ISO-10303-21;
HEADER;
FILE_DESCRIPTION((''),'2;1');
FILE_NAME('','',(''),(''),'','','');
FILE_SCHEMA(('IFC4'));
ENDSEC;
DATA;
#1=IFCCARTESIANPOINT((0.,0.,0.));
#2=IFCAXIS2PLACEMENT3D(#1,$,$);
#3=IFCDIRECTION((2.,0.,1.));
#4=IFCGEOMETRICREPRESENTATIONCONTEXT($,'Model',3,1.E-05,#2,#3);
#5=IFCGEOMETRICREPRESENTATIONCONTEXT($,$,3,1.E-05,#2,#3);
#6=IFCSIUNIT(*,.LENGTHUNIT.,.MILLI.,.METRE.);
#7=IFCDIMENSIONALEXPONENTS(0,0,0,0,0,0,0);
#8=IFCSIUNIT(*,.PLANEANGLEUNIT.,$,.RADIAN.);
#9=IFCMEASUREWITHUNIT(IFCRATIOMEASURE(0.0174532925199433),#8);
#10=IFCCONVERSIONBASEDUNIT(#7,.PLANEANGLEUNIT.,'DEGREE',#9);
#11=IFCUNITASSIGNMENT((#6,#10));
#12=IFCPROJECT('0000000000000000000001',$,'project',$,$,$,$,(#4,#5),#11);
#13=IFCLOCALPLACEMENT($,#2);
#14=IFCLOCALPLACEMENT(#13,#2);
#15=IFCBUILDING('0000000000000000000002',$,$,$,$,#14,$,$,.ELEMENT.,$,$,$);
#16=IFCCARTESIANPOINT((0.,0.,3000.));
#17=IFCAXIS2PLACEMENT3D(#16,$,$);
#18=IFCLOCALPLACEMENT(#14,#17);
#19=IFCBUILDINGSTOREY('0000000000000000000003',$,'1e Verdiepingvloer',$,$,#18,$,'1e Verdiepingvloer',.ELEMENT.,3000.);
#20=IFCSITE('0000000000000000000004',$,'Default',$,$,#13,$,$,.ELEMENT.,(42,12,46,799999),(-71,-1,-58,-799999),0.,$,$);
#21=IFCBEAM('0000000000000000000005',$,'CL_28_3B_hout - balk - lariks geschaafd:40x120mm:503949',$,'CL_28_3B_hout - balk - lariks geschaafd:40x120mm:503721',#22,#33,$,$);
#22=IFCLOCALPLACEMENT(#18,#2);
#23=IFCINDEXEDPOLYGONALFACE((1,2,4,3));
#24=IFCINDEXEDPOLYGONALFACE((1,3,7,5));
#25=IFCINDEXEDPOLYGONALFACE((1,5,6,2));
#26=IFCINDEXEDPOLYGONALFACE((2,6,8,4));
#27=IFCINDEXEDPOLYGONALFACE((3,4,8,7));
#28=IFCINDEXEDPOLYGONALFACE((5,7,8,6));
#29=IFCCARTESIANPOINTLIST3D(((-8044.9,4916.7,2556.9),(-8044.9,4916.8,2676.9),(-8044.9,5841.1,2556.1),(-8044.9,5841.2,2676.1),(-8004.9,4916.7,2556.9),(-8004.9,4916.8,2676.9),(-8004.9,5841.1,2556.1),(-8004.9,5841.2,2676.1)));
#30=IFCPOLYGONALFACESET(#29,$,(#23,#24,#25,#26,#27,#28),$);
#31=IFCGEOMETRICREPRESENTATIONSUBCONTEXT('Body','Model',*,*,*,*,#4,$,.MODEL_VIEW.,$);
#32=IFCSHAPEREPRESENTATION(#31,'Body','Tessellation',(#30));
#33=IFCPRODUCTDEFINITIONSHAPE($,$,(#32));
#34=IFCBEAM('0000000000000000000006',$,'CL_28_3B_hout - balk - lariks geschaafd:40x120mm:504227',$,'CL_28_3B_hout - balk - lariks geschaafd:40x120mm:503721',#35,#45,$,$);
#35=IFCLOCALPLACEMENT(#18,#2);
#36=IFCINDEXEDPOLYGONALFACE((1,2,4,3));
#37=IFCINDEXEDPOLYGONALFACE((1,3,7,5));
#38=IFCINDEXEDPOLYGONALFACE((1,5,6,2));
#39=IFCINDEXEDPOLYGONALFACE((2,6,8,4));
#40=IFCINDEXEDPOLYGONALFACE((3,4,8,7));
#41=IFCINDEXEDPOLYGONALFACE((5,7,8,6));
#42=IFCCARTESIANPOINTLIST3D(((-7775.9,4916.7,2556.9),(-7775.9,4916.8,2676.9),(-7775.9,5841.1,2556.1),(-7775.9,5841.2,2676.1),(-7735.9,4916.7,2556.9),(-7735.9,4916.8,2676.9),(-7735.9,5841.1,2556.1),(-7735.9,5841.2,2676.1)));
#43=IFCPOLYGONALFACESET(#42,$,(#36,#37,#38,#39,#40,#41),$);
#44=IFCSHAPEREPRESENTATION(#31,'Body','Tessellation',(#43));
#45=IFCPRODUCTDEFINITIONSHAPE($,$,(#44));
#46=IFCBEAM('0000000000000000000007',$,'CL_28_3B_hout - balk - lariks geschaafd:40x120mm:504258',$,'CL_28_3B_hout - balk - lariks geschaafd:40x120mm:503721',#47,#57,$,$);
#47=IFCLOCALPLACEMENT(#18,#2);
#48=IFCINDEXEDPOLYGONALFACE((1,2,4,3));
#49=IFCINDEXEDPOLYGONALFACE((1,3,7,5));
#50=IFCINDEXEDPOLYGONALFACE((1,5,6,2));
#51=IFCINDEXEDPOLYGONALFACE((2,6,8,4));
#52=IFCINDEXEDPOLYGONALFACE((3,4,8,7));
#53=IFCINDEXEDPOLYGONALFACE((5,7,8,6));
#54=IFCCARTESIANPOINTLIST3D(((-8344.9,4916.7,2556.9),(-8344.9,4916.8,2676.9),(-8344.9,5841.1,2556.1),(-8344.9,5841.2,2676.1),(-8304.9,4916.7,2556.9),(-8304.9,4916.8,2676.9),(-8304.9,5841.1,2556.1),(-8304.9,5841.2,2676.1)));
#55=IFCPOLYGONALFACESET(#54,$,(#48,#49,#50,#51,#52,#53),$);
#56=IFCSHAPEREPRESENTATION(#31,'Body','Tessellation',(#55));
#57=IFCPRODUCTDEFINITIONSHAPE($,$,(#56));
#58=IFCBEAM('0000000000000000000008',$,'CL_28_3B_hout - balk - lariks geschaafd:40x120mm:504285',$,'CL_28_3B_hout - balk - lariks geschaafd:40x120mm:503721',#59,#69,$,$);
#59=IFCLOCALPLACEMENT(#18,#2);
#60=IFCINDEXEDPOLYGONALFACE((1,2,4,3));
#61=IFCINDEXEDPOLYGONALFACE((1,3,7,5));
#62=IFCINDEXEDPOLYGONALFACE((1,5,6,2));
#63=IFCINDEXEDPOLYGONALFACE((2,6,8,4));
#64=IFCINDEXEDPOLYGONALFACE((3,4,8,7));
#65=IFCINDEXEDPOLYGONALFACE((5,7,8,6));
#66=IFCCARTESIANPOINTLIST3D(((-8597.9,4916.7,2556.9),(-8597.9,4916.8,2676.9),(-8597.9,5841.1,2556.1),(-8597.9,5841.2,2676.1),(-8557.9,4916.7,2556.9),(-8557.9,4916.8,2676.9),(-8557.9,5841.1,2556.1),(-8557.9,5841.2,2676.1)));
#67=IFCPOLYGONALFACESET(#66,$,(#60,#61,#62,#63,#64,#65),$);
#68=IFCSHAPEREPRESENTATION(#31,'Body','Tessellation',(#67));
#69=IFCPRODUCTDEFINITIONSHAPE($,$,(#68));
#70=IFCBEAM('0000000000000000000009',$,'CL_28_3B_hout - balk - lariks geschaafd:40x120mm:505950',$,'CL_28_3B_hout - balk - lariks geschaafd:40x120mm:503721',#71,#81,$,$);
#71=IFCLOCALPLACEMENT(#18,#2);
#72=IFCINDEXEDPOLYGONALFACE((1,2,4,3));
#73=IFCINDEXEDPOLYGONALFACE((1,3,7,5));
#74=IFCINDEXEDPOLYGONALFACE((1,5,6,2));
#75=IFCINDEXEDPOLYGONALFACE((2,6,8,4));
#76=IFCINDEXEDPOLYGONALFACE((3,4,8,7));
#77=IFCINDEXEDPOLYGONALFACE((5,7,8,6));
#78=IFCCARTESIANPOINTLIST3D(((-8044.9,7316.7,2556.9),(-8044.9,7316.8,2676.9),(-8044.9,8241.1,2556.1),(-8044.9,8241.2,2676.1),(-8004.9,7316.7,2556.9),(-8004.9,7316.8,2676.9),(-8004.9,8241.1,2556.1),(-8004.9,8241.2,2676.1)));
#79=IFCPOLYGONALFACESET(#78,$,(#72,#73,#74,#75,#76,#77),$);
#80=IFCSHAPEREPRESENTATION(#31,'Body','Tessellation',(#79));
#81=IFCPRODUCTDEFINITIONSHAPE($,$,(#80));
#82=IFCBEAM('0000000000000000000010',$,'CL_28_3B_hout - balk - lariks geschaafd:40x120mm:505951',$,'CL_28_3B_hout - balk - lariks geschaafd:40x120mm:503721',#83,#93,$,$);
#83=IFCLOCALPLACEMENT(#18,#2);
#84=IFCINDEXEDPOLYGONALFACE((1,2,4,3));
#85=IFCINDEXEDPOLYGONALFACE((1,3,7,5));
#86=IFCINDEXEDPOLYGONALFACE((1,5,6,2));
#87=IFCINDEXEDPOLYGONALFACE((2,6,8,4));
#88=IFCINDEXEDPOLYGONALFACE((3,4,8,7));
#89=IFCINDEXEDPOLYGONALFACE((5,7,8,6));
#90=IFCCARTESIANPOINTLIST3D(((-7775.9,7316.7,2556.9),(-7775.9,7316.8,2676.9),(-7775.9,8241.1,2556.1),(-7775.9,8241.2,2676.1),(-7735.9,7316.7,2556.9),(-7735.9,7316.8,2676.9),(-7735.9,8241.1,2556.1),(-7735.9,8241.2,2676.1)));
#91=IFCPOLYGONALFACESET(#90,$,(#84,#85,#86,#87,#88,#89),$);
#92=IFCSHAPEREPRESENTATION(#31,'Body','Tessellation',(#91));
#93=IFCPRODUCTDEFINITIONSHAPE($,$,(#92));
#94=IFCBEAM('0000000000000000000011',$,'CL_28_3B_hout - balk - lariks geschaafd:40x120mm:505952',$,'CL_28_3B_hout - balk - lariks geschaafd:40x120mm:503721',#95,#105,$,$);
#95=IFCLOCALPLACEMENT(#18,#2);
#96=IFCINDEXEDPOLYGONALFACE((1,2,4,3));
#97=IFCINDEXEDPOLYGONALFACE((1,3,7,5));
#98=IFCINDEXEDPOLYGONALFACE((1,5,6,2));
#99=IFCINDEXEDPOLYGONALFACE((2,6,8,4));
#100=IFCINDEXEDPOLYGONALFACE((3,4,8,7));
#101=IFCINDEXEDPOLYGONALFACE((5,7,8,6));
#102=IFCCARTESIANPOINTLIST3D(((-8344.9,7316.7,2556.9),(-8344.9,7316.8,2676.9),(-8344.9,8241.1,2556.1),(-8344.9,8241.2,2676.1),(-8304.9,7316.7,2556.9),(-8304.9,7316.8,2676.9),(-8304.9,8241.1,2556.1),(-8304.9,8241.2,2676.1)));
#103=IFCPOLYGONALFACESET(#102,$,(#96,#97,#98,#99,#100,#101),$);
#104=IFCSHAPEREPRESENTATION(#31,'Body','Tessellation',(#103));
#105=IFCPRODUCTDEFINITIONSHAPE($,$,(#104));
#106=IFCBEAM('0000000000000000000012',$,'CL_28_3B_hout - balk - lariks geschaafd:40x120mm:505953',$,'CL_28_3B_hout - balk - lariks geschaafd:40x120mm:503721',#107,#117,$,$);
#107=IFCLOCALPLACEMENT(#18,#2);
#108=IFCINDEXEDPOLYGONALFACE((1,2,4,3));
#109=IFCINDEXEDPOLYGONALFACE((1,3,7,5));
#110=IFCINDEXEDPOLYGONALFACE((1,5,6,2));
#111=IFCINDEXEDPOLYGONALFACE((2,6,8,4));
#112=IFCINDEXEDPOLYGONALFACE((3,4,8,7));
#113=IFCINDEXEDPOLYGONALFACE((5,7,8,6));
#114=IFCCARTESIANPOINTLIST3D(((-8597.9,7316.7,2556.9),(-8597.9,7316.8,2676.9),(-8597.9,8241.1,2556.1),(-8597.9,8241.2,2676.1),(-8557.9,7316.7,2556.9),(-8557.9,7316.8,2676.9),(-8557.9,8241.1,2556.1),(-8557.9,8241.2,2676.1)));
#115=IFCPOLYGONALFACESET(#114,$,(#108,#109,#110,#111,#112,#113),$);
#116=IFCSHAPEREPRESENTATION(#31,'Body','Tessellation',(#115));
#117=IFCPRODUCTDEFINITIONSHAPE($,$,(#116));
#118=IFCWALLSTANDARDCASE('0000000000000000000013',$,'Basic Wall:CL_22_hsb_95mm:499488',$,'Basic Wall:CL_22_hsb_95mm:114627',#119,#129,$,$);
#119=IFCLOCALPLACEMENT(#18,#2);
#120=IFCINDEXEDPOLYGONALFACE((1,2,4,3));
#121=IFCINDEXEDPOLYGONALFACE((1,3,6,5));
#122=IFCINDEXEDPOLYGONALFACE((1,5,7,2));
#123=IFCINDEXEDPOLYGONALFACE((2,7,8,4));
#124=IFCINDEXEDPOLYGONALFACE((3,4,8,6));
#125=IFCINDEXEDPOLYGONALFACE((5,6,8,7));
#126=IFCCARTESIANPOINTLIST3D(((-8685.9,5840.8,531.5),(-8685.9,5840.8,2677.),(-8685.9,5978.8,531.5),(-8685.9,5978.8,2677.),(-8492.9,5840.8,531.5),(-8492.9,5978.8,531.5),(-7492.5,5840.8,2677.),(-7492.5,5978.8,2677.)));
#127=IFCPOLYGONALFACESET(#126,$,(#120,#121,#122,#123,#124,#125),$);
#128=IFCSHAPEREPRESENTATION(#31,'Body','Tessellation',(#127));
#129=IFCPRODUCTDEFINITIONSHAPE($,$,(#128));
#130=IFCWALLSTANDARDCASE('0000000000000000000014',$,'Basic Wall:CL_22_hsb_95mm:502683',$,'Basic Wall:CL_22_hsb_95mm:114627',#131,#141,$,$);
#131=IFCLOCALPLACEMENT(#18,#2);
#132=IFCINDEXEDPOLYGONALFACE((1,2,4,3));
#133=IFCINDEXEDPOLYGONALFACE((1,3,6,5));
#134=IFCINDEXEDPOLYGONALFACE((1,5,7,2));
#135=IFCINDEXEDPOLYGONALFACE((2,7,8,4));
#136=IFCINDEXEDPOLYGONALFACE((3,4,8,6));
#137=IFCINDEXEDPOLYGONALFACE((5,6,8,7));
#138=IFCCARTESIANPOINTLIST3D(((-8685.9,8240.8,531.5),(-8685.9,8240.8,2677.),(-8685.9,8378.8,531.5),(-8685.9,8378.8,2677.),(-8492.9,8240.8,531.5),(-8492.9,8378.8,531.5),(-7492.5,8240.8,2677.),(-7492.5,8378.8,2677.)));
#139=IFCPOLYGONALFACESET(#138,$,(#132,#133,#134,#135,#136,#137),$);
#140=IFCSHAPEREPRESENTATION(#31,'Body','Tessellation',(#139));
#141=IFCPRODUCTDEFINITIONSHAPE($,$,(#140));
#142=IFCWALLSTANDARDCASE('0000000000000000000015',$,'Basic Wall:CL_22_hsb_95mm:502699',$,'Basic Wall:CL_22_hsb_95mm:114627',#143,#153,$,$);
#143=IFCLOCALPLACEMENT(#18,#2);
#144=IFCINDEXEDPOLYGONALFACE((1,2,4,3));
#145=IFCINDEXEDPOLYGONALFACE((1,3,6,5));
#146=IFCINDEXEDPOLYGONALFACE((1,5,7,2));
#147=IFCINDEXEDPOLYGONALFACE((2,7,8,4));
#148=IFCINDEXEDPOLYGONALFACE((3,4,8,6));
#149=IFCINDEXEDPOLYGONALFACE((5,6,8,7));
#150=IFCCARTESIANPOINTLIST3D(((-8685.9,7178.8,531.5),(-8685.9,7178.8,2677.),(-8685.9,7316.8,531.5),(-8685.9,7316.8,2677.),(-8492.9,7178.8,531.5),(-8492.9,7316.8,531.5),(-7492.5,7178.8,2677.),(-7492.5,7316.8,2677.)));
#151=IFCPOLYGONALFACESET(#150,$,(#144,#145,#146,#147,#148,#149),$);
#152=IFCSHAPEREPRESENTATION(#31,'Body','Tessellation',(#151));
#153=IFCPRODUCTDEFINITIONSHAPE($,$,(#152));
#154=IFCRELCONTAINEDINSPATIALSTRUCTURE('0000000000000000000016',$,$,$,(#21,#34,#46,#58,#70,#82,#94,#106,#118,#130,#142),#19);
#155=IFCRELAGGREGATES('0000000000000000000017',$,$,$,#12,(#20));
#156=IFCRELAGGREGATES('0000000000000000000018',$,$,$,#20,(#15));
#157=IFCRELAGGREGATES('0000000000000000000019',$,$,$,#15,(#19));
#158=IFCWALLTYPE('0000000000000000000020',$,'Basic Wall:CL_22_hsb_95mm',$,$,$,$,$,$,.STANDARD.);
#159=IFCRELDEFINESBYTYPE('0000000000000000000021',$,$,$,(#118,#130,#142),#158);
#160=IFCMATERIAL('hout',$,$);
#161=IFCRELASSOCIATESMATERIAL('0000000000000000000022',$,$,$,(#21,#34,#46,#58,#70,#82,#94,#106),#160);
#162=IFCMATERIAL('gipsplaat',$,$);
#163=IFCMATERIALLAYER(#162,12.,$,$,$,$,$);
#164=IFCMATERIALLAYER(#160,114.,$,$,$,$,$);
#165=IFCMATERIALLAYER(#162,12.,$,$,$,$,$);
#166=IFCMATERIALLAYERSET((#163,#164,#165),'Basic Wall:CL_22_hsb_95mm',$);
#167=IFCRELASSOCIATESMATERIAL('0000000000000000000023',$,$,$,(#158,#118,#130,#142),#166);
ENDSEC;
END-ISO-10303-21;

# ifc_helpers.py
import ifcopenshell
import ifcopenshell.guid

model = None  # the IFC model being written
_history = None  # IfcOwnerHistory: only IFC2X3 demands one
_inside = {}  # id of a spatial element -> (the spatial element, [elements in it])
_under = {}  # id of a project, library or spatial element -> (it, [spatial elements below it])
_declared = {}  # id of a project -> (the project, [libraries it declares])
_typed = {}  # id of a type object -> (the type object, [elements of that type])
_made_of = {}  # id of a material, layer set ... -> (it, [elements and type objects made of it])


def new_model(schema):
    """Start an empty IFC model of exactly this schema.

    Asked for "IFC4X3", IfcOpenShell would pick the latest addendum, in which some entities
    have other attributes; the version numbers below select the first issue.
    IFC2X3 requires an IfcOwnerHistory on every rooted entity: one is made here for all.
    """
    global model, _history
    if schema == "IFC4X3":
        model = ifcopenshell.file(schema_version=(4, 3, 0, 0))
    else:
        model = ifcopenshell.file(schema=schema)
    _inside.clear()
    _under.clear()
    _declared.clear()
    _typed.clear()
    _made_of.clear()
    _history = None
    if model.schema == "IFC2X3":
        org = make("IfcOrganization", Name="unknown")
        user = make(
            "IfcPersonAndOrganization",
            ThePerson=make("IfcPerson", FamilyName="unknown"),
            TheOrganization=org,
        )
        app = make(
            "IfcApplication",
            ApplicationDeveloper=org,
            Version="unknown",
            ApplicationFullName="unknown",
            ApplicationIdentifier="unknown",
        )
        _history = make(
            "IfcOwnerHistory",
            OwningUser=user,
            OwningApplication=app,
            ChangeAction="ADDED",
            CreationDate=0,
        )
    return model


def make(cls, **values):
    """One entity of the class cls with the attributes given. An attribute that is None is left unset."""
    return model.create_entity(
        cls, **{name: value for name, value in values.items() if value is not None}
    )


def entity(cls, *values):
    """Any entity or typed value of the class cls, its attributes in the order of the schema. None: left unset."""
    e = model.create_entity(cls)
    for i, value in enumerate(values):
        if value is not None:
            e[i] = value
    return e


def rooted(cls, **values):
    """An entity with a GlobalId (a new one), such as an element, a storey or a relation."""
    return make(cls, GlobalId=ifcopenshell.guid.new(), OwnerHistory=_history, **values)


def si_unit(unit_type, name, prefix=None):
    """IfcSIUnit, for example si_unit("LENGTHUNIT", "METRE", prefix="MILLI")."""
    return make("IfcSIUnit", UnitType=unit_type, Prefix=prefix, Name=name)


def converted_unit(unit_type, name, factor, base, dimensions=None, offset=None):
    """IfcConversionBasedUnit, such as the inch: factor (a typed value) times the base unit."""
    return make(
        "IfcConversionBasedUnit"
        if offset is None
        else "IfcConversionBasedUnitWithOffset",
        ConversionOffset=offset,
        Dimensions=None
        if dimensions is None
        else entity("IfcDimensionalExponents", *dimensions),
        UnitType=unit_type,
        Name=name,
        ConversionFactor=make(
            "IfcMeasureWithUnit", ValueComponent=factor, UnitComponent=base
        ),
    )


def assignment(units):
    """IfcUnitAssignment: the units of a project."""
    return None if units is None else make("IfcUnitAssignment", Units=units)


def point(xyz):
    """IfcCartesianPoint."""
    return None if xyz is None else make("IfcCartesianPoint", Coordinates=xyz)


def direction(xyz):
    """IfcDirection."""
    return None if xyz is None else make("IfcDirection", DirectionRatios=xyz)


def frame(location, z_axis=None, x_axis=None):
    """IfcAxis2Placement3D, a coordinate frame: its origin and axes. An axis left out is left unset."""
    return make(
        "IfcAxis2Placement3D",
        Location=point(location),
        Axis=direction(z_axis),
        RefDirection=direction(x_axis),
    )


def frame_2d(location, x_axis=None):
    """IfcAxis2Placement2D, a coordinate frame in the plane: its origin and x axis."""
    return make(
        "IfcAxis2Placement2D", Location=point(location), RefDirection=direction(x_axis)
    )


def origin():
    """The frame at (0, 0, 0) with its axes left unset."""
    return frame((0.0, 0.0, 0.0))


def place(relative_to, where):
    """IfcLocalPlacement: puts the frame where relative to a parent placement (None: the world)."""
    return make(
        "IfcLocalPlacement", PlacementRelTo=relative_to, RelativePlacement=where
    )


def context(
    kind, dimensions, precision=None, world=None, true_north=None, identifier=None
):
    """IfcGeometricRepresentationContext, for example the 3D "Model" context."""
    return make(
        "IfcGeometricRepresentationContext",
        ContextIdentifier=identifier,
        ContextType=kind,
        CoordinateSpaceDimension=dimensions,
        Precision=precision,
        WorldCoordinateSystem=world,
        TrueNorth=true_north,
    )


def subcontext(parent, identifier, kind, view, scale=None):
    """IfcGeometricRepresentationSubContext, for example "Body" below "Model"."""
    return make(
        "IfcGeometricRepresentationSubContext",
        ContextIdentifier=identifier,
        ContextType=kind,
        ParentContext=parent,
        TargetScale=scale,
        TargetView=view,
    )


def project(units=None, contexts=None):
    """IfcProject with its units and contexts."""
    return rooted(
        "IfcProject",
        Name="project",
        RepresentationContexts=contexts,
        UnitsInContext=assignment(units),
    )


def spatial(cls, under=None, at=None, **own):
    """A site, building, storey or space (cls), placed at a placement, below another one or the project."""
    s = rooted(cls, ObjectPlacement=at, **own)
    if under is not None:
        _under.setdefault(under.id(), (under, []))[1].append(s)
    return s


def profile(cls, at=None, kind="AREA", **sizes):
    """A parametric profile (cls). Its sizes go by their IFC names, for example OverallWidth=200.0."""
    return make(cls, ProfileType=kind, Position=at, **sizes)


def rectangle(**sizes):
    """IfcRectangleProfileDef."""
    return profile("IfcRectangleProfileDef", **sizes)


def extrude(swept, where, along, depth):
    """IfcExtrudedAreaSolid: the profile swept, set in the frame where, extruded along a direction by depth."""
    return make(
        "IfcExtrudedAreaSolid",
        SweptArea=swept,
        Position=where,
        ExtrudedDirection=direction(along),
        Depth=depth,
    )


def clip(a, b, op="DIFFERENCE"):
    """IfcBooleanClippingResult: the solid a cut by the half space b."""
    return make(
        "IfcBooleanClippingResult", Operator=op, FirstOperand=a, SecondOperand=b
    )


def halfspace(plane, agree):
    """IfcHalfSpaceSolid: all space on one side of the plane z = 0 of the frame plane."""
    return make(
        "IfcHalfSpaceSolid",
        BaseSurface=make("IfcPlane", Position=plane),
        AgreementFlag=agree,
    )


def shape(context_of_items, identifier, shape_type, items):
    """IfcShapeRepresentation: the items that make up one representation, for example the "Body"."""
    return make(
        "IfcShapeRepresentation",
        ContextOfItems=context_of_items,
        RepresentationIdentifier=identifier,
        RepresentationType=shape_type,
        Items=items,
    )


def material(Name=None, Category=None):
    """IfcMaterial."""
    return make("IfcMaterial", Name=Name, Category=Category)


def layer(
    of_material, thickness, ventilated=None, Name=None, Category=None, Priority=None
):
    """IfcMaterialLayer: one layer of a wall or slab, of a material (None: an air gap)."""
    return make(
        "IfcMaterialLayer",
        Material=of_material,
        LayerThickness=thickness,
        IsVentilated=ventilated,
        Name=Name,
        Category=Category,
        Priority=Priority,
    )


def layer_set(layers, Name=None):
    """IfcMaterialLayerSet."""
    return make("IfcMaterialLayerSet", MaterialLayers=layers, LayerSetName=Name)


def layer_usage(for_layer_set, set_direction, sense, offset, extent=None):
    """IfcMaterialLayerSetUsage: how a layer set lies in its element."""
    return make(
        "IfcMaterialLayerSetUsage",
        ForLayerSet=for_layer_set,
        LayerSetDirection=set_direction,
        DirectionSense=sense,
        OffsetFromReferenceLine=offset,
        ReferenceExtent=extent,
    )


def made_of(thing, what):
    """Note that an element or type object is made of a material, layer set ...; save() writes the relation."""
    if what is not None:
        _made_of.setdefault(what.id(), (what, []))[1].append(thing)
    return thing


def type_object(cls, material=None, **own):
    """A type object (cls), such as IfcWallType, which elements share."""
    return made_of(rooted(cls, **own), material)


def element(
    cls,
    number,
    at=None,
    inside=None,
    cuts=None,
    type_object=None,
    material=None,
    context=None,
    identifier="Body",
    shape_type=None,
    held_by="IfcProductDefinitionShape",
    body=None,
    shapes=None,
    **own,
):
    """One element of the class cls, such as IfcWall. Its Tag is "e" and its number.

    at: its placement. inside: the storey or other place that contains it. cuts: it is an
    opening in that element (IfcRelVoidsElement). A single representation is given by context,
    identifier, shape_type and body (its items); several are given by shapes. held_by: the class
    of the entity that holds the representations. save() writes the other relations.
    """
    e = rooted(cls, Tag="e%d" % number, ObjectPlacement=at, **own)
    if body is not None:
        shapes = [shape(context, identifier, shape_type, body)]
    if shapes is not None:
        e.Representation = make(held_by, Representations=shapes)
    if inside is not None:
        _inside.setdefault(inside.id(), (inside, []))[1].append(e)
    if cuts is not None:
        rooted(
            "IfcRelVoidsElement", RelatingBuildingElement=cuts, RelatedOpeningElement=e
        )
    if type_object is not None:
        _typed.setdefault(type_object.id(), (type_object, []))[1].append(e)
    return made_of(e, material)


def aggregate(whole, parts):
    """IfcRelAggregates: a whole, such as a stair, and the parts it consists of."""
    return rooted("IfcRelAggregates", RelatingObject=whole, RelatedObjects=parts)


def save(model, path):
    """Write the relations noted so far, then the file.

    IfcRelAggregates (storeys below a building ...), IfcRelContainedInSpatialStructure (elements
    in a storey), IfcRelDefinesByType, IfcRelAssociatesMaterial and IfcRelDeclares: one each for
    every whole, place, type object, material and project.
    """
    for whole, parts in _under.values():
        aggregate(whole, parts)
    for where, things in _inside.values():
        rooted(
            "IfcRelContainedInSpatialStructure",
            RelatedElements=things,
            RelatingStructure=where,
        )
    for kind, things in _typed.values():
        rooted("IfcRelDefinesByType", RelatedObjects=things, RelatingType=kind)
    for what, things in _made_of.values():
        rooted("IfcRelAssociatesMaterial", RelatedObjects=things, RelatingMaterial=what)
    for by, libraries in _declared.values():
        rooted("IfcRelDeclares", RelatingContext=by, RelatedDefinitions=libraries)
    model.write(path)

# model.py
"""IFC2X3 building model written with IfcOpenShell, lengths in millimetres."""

from ifc_helpers import new_model, entity, si_unit, converted_unit, direction, frame, frame_2d, origin, place, context, subcontext, project, spatial, rectangle, extrude, clip, halfspace, material, layer, layer_set, layer_usage, type_object, element, save


model = new_model("IFC2X3")

# Units and contexts
model_context = context("Model", 3, precision=1e-05, world=origin(), true_north=direction((2.0, 0.0, 1.0)))
context_of_model = context(None, 3, precision=1e-05, world=origin(), true_north=direction((2.0, 0.0, 1.0)))
body_context = subcontext(model_context, "Body", "Model", "MODEL_VIEW")
ifc_project = project(units=[si_unit("LENGTHUNIT", "METRE", prefix="MILLI"), converted_unit("PLANEANGLEUNIT", "DEGREE", entity("IfcRatioMeasure", 0.0174532925199433), si_unit("PLANEANGLEUNIT", "RADIAN"), dimensions=[0, 0, 0, 0, 0, 0, 0])], contexts=[model_context, context_of_model])

# Site, building, storey
site_placement = place(None, origin())
site = spatial("IfcSite", under=ifc_project, at=site_placement, Name="Default", CompositionType="ELEMENT", RefLatitude=(42, 12, 46, 799999), RefLongitude=(-71, -1, -58, -799999), RefElevation=0.0)
building_placement = place(site_placement, origin())
building = spatial("IfcBuilding", under=site, at=building_placement, CompositionType="ELEMENT")
storey_placement = place(building_placement, frame((0.0, 0.0, 3000.0)))
storey = spatial("IfcBuildingStorey", under=building, at=storey_placement, Name="1e Verdiepingvloer", LongName="1e Verdiepingvloer", CompositionType="ELEMENT", Elevation=3000.0)

# Beams
ifc_material_1 = material(Name="hout")
for number, where, z_axis, x_axis, name in (
    (1, (-8024.9, 5909.8, 2676.0), (0.0, 0.000942, 1.0), (0.0, -1.0, 0.000942), "CL_28_3B_hout - balk - lariks geschaafd:40x120mm:503949"),
    (2, (-7755.9, 5909.8, 2676.0), (0.0, 0.000942, 1.0), (0.0, -1.0, 0.000942), "CL_28_3B_hout - balk - lariks geschaafd:40x120mm:504227"),
    (3, (-8324.9, 5909.8, 2676.0), (0.0, 0.000942, 1.0), (0.0, -1.0, 0.000942), "CL_28_3B_hout - balk - lariks geschaafd:40x120mm:504258"),
    (4, (-8577.9, 5909.8, 2676.0), (0.0, 0.000942, 1.0), (0.0, -1.0, 0.000942), "CL_28_3B_hout - balk - lariks geschaafd:40x120mm:504285"),
):
    element("IfcBeam", number, at=place(storey_placement, frame(where, z_axis=z_axis, x_axis=x_axis)), inside=storey, material=ifc_material_1, Name=name, ObjectType="CL_28_3B_hout - balk - lariks geschaafd:40x120mm:503721", context=body_context, shape_type="SweptSolid", body=[
        extrude(rectangle(XDim=120.0, YDim=40.0, at=frame_2d((0.0, 0.0), x_axis=(1.0, 0.0))), frame((68.6, 0.0, -60.0), z_axis=(1.0, 0.0, 0.0), x_axis=(0.0, 0.0, -1.0)), (0.0, 0.0, 1.0), 924.4),
    ])
for number, where, z_axis, x_axis, name in (
    (5, (-8024.9, 8309.8, 2676.0), (0.0, 0.000942, 1.0), (0.0, -1.0, 0.000942), "CL_28_3B_hout - balk - lariks geschaafd:40x120mm:505950"),
    (6, (-7755.9, 8309.8, 2676.0), (0.0, 0.000942, 1.0), (0.0, -1.0, 0.000942), "CL_28_3B_hout - balk - lariks geschaafd:40x120mm:505951"),
    (7, (-8324.9, 8309.8, 2676.0), (0.0, 0.000942, 1.0), (0.0, -1.0, 0.000942), "CL_28_3B_hout - balk - lariks geschaafd:40x120mm:505952"),
    (8, (-8577.9, 8309.8, 2676.0), (0.0, 0.000942, 1.0), (0.0, -1.0, 0.000942), "CL_28_3B_hout - balk - lariks geschaafd:40x120mm:505953"),
):
    element("IfcBeam", number, at=place(storey_placement, frame(where, z_axis=z_axis, x_axis=x_axis)), inside=storey, material=ifc_material_1, Name=name, ObjectType="CL_28_3B_hout - balk - lariks geschaafd:40x120mm:503721", context=body_context, shape_type="SweptSolid", body=[
        extrude(rectangle(XDim=120.0, YDim=40.0, at=frame_2d((0.0, 0.0), x_axis=(1.0, 0.0))), frame((68.6, 0.0, -60.0), z_axis=(1.0, 0.0, 0.0), x_axis=(0.0, 0.0, -1.0)), (0.0, 0.0, 1.0), 924.4),
    ])

# Walls
ifc_material_2 = material(Name="gipsplaat")
ifc_layer_1 = layer(ifc_material_2, 12.0)
ifc_layer_2 = layer(ifc_material_1, 114.0)
ifc_layer_3 = layer(ifc_material_2, 12.0)
ifc_layer_set = layer_set([ifc_layer_1, ifc_layer_2, ifc_layer_3], Name="Basic Wall:CL_22_hsb_95mm")
ifc_layer_usage_1 = layer_usage(ifc_layer_set, "AXIS2", "POSITIVE", -69.0)
wall_type = type_object("IfcWallType", Name="Basic Wall:CL_22_hsb_95mm", PredefinedType="STANDARD", material=ifc_layer_set)
wall_1_placement = place(storey_placement, frame((-7492.5, 5909.8, 0.0), z_axis=(0.0, 0.0, 1.0), x_axis=(-1.0, 0.0, 0.0)))
element("IfcWallStandardCase", 9, at=wall_1_placement, inside=storey, type_object=wall_type, material=ifc_layer_usage_1, Name="Basic Wall:CL_22_hsb_95mm:499488", ObjectType="Basic Wall:CL_22_hsb_95mm:114627", context=body_context, shape_type="Clipping", body=[
    clip(clip(extrude(rectangle(XDim=1193.5, YDim=138.0, at=frame_2d((596.7, 0.0), x_axis=(-1.0, 0.0))), origin(), (0.0, 0.0, 1.0), 2677.0), halfspace(frame((1000.5, -69.0, 531.5), z_axis=(-0.906308, 0.0, -0.422618), x_axis=(0.0, 1.0, 0.0)), False)), halfspace(frame((1193.5, -69.0, 531.5), z_axis=(0.0, 0.0, -1.0), x_axis=(0.0, 1.0, 0.0)), False)),
])
ifc_layer_usage_2 = layer_usage(ifc_layer_set, "AXIS2", "POSITIVE", -69.0)
wall_2_placement = place(storey_placement, frame((-7492.5, 8309.8, 0.0), z_axis=(0.0, 0.0, 1.0), x_axis=(-1.0, 0.0, 0.0)))
element("IfcWallStandardCase", 10, at=wall_2_placement, inside=storey, type_object=wall_type, material=ifc_layer_usage_2, Name="Basic Wall:CL_22_hsb_95mm:502683", ObjectType="Basic Wall:CL_22_hsb_95mm:114627", context=body_context, shape_type="Clipping", body=[
    clip(clip(extrude(rectangle(XDim=1193.5, YDim=138.0, at=frame_2d((596.7, 0.0), x_axis=(-1.0, 0.0))), origin(), (0.0, 0.0, 1.0), 2677.0), halfspace(frame((1000.5, -69.0, 531.5), z_axis=(-0.906308, 0.0, -0.422618), x_axis=(0.0, 1.0, 0.0)), False)), halfspace(frame((1193.5, -69.0, 531.5), z_axis=(0.0, 0.0, -1.0), x_axis=(0.0, 1.0, 0.0)), False)),
])
ifc_layer_usage_3 = layer_usage(ifc_layer_set, "AXIS2", "POSITIVE", -69.0)
wall_3_placement = place(storey_placement, frame((-7492.5, 7247.8, 0.0), z_axis=(0.0, 0.0, 1.0), x_axis=(-1.0, 0.0, 0.0)))
element("IfcWallStandardCase", 11, at=wall_3_placement, inside=storey, type_object=wall_type, material=ifc_layer_usage_3, Name="Basic Wall:CL_22_hsb_95mm:502699", ObjectType="Basic Wall:CL_22_hsb_95mm:114627", context=body_context, shape_type="Clipping", body=[
    clip(clip(extrude(rectangle(XDim=1193.5, YDim=138.0, at=frame_2d((596.7, 0.0), x_axis=(-1.0, 0.0))), origin(), (0.0, 0.0, 1.0), 2677.0), halfspace(frame((1000.5, -69.0, 531.5), z_axis=(-0.906308, 0.0, -0.422618), x_axis=(0.0, 1.0, 0.0)), False)), halfspace(frame((1193.5, -69.0, 531.5), z_axis=(0.0, 0.0, -1.0), x_axis=(0.0, 1.0, 0.0)), False)),
])

save(model, "model.ifc")
